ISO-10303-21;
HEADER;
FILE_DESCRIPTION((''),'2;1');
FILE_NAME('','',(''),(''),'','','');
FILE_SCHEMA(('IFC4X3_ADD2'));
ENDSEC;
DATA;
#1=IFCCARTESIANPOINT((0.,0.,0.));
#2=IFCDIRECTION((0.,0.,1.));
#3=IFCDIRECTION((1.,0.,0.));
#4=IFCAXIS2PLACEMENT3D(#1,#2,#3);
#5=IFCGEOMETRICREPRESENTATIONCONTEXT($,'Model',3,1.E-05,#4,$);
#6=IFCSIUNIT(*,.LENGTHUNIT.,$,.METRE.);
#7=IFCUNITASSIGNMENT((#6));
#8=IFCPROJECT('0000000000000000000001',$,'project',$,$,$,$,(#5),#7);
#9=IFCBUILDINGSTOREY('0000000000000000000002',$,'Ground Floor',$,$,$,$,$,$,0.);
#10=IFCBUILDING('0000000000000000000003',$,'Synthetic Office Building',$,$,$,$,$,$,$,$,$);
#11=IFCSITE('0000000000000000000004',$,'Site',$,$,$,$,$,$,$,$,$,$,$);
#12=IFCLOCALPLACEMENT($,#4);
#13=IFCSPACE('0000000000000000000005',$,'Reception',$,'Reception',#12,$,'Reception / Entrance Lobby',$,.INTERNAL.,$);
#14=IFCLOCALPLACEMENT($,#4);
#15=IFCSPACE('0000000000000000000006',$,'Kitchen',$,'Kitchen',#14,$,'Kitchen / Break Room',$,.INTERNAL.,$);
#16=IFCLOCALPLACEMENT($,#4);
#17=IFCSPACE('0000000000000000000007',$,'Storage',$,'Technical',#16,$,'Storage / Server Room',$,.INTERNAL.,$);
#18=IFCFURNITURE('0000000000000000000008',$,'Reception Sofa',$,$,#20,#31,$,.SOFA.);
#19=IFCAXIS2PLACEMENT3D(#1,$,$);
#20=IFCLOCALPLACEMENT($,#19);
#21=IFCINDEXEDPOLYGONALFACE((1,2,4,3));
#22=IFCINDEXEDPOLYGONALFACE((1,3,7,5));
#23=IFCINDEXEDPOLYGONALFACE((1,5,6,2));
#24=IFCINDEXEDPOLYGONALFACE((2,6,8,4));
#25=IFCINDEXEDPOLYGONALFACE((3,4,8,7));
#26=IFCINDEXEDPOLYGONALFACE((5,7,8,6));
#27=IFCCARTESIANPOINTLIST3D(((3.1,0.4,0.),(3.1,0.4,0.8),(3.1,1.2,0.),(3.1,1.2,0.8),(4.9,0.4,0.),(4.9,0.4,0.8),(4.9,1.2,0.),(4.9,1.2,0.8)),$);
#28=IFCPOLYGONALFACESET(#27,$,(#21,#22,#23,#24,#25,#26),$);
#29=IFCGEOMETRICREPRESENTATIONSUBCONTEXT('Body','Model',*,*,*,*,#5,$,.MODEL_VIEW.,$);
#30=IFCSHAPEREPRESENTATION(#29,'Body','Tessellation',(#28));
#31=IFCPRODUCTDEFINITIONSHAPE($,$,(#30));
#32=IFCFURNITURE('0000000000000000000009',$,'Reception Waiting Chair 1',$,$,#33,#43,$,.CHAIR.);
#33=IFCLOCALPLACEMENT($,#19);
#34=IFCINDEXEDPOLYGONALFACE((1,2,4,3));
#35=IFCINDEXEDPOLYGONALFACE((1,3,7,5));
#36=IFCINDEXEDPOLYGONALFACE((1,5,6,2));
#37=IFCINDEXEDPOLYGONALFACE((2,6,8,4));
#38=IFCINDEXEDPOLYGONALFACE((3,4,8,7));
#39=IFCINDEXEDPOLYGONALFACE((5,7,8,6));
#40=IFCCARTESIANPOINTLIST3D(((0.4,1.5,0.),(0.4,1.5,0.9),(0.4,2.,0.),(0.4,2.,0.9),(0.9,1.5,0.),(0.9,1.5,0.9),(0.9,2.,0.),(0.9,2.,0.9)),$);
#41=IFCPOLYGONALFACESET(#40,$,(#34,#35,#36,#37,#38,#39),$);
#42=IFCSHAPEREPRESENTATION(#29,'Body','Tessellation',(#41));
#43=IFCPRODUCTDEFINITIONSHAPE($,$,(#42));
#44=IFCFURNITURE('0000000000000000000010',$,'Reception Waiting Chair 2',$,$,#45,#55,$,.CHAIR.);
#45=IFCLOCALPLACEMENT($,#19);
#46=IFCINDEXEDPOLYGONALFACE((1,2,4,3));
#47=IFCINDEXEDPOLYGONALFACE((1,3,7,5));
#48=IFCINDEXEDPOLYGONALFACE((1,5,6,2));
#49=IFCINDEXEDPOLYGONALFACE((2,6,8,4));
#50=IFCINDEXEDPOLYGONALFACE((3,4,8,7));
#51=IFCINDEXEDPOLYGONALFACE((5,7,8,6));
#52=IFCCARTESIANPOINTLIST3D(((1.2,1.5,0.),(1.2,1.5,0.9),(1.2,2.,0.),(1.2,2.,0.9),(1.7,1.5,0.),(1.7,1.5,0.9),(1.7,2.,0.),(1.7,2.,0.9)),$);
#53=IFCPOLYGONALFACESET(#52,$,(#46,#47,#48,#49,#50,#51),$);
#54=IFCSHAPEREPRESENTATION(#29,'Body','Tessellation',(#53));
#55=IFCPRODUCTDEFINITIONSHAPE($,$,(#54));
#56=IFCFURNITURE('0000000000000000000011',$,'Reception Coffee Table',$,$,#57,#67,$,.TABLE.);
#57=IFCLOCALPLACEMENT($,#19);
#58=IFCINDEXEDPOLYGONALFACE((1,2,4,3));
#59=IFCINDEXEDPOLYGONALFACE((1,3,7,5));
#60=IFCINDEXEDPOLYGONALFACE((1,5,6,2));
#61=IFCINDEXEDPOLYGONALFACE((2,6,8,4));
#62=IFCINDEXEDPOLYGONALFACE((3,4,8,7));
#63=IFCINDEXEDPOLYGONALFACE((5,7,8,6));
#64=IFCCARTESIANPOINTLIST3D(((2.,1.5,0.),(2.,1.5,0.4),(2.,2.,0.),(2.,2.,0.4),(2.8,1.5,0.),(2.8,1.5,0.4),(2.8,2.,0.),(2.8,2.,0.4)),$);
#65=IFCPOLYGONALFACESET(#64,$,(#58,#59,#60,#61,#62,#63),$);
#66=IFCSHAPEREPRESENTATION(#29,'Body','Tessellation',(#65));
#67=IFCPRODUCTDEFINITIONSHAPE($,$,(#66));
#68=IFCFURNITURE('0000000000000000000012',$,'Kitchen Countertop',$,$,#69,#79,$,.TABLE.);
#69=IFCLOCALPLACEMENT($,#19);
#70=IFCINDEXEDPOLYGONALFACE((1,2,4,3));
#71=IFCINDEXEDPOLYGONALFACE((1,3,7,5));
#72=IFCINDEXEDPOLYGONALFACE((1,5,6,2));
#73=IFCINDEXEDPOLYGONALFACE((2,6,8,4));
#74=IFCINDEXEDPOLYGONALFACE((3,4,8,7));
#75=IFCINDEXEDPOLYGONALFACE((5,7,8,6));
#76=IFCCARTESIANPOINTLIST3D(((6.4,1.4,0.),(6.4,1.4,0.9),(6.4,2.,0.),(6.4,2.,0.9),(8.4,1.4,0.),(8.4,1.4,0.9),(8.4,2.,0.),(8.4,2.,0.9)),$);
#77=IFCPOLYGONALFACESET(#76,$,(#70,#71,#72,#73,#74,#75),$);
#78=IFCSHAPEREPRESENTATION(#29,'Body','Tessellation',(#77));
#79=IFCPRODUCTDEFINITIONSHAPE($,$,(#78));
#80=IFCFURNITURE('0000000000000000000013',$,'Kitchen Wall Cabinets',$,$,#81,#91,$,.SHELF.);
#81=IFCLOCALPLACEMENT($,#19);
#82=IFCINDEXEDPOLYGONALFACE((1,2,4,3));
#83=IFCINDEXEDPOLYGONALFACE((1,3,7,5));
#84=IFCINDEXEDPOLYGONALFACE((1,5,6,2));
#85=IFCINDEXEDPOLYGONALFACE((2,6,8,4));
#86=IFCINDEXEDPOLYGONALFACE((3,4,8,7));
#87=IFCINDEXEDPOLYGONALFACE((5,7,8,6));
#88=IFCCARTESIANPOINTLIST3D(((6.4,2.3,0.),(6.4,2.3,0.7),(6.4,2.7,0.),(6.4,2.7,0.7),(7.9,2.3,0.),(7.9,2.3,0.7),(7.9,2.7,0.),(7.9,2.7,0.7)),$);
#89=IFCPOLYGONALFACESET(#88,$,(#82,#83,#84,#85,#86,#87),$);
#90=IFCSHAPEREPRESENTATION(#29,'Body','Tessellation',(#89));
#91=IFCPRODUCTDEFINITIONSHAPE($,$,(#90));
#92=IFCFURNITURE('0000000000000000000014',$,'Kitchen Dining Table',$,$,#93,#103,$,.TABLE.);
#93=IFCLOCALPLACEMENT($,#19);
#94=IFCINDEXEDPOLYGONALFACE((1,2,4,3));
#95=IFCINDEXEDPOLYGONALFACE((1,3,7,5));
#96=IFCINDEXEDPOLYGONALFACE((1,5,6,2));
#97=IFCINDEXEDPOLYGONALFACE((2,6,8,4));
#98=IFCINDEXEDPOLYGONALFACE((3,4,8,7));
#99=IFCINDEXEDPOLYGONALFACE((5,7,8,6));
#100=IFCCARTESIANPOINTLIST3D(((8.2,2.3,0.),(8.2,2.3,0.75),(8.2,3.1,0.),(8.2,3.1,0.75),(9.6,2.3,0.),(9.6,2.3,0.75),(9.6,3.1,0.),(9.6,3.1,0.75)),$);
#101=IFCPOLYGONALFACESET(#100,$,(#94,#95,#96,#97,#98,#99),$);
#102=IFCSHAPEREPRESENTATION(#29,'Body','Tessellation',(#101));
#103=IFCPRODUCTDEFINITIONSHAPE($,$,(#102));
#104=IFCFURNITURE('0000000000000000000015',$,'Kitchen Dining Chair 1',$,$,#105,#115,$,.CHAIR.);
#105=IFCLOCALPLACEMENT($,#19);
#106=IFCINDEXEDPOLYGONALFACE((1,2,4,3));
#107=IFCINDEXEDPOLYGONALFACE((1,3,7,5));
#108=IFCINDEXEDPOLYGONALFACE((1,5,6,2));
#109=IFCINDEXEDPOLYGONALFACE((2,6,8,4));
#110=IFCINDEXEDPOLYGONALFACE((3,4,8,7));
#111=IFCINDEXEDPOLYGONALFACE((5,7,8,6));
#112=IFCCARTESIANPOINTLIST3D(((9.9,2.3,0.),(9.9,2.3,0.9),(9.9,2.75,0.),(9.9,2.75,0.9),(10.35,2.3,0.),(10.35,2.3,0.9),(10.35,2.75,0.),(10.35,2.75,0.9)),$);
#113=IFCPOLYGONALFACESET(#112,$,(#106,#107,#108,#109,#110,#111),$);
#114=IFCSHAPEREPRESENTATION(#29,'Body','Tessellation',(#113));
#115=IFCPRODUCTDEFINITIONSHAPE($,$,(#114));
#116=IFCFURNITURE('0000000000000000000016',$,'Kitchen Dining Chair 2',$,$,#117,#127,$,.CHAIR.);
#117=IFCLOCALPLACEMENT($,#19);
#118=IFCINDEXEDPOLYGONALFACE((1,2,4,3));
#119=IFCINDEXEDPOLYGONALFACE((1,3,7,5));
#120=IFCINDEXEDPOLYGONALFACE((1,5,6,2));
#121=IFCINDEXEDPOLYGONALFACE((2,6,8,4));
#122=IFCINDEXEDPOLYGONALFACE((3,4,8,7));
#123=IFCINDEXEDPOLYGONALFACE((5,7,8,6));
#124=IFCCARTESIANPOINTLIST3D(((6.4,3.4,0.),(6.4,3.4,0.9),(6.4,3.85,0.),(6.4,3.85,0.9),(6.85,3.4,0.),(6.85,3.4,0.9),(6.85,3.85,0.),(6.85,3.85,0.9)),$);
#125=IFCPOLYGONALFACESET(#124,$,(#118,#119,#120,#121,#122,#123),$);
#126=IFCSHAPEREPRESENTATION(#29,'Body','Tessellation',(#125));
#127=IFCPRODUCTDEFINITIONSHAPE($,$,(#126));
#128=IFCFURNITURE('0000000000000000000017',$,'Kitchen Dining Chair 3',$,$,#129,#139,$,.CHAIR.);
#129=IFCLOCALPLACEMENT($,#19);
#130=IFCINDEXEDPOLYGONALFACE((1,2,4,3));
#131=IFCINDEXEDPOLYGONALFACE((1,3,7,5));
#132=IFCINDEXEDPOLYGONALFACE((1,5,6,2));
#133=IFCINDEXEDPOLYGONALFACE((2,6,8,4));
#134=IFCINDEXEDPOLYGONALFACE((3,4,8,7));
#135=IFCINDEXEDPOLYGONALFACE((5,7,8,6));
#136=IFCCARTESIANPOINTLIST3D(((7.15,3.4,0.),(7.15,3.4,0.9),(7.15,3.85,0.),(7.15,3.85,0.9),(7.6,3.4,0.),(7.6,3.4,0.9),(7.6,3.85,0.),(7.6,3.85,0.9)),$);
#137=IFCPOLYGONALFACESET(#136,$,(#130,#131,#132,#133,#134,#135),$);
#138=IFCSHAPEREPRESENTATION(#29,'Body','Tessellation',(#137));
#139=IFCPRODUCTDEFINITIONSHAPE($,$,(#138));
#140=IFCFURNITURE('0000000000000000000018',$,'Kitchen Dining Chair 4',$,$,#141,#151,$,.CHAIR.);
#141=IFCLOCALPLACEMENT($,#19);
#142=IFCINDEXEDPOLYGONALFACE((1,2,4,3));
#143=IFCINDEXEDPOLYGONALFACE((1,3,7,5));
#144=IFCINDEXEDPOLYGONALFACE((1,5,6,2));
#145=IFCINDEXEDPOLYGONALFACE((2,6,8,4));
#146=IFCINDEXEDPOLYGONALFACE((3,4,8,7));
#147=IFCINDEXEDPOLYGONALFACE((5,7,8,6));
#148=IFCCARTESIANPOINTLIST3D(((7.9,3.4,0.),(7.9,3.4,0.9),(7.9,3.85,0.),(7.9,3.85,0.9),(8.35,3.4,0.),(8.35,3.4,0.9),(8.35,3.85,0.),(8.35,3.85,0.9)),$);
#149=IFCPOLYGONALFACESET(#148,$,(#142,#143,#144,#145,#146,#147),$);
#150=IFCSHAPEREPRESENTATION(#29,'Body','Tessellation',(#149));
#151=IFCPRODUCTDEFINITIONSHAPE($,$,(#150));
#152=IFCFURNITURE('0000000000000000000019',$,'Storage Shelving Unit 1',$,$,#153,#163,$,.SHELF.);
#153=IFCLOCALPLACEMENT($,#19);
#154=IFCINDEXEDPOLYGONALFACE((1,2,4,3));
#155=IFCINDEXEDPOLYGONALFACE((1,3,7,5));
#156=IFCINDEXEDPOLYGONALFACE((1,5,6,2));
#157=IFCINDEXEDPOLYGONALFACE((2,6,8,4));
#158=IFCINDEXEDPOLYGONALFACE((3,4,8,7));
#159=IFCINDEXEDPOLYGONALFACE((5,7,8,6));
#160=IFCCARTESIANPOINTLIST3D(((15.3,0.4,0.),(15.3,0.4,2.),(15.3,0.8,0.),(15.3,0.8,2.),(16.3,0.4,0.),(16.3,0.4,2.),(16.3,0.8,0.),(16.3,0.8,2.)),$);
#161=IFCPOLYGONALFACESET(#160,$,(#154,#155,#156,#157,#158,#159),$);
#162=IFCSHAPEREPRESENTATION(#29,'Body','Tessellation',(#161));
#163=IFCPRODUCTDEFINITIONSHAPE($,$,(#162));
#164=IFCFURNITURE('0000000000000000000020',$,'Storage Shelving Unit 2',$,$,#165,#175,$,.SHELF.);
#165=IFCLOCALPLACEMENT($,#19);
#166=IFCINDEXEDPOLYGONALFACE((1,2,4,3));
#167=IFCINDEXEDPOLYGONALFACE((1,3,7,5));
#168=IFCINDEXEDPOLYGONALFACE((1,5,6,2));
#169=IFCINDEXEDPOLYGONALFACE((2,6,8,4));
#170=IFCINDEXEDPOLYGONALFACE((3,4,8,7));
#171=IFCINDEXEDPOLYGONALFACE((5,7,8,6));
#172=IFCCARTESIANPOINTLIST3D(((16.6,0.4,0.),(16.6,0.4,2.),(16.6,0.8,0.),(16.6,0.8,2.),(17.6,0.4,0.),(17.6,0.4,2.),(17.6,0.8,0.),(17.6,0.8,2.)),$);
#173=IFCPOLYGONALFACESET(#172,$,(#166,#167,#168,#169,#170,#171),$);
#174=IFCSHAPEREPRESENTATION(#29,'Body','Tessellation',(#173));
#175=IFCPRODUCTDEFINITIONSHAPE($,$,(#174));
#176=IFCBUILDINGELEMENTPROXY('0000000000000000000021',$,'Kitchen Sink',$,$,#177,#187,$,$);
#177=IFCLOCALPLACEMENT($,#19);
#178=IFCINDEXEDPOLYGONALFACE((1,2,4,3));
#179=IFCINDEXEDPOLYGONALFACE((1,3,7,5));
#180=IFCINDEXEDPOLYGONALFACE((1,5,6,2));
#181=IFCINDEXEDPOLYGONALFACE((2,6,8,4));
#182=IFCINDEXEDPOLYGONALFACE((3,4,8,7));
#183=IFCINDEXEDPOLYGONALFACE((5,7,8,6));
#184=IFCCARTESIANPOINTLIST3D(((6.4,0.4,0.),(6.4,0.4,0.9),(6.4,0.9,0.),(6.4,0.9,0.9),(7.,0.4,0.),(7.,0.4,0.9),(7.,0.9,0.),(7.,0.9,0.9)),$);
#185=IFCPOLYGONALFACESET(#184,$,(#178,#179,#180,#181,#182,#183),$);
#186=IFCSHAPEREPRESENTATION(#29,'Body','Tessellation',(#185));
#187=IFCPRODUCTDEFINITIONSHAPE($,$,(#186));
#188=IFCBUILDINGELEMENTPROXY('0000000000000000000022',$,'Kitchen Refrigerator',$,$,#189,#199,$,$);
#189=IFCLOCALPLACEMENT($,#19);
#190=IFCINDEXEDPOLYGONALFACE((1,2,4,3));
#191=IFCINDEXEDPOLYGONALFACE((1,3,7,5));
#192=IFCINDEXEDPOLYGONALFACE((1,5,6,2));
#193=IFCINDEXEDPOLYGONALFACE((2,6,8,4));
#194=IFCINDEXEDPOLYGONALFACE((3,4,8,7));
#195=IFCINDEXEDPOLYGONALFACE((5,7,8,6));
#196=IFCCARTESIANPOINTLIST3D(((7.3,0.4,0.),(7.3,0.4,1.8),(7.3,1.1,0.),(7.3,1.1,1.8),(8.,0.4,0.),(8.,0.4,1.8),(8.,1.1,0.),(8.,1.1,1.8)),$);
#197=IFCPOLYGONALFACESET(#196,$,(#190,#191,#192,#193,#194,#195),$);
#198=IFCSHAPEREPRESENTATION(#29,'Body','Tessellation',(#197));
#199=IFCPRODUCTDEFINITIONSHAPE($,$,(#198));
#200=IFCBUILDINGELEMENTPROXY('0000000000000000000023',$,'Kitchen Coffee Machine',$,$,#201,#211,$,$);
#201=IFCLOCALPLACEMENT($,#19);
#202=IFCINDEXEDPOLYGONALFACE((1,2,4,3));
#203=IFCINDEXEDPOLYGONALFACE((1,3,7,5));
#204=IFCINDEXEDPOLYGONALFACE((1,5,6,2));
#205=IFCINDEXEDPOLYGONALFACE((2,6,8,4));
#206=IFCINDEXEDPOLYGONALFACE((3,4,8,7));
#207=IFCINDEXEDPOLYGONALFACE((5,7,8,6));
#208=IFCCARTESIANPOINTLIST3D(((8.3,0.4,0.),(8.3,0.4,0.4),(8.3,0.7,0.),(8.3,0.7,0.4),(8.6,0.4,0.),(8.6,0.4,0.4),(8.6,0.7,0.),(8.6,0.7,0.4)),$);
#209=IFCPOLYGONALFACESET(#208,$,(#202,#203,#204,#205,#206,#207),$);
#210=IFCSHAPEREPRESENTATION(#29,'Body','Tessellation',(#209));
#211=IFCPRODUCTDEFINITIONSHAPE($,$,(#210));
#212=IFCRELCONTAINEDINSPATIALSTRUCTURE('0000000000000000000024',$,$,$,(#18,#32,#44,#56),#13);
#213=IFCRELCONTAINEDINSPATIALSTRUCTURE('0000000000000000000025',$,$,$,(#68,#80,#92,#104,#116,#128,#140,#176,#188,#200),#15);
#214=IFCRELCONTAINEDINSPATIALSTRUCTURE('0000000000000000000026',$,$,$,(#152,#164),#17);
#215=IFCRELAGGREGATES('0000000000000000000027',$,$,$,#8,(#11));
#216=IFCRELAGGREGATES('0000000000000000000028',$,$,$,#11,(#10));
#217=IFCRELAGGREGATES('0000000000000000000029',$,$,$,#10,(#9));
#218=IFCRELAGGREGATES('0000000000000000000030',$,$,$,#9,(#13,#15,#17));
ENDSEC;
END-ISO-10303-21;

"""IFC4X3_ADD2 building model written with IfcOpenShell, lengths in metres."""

from ifc_helpers import new_model, si_unit, origin_with_axes, place, context, subcontext, project, spatial, polyline, outline, extrude, element, save


model = new_model("IFC4X3_ADD2")

# Units and contexts
model_context = context("Model", 3, precision=1e-05, world=origin_with_axes())
body_context = subcontext(model_context, "Body", "Model", "MODEL_VIEW")
ifc_project = project(units=[si_unit("LENGTHUNIT", "METRE")], contexts=[model_context])

# Site, building, storey, space
site = spatial("IfcSite", under=ifc_project, Name="Site")
building = spatial("IfcBuilding", under=site, Name="Synthetic Office Building")
storey = spatial("IfcBuildingStorey", under=building, Name="Ground Floor", Elevation=0.0)
space_1_placement = place(None, origin_with_axes())
space_1 = spatial("IfcSpace", under=storey, at=space_1_placement, Name="Reception", ObjectType="Reception", LongName="Reception / Entrance Lobby", PredefinedType="INTERNAL")

# Furniture
furniture_1_placement = place(space_1_placement, origin_with_axes())
element("IfcFurniture", 1, at=furniture_1_placement, inside=space_1, Name="Reception Sofa", PredefinedType="SOFA", context=body_context, shape_type="SweptSolid", body=[
    extrude(outline(polyline([(3.1, 0.4), (4.9, 0.4), (4.9, 1.2), (3.1, 1.2), (3.1, 0.4)])), origin_with_axes(), (0.0, 0.0, 1.0), 0.8),
])
furniture_2_placement = place(space_1_placement, origin_with_axes())
element("IfcFurniture", 2, at=furniture_2_placement, inside=space_1, Name="Reception Waiting Chair 1", PredefinedType="CHAIR", context=body_context, shape_type="SweptSolid", body=[
    extrude(outline(polyline([(0.4, 1.5), (0.9, 1.5), (0.9, 2.0), (0.4, 2.0), (0.4, 1.5)])), origin_with_axes(), (0.0, 0.0, 1.0), 0.9),
])
furniture_3_placement = place(space_1_placement, origin_with_axes())
element("IfcFurniture", 3, at=furniture_3_placement, inside=space_1, Name="Reception Waiting Chair 2", PredefinedType="CHAIR", context=body_context, shape_type="SweptSolid", body=[
    extrude(outline(polyline([(1.2, 1.5), (1.7, 1.5), (1.7, 2.0), (1.2, 2.0), (1.2, 1.5)])), origin_with_axes(), (0.0, 0.0, 1.0), 0.9),
])
furniture_4_placement = place(space_1_placement, origin_with_axes())
element("IfcFurniture", 4, at=furniture_4_placement, inside=space_1, Name="Reception Coffee Table", PredefinedType="TABLE", context=body_context, shape_type="SweptSolid", body=[
    extrude(outline(polyline([(2.0, 1.5), (2.8, 1.5), (2.8, 2.0), (2.0, 2.0), (2.0, 1.5)])), origin_with_axes(), (0.0, 0.0, 1.0), 0.4),
])

# Shared definitions
space_2_placement = place(None, origin_with_axes())
space_2 = spatial("IfcSpace", under=storey, at=space_2_placement, Name="Kitchen", ObjectType="Kitchen", LongName="Kitchen / Break Room", PredefinedType="INTERNAL")

# Furniture
furniture_5_placement = place(space_2_placement, origin_with_axes())
element("IfcFurniture", 5, at=furniture_5_placement, inside=space_2, Name="Kitchen Countertop", PredefinedType="TABLE", context=body_context, shape_type="SweptSolid", body=[
    extrude(outline(polyline([(6.4, 1.4), (8.4, 1.4), (8.4, 2.0), (6.4, 2.0), (6.4, 1.4)])), origin_with_axes(), (0.0, 0.0, 1.0), 0.9),
])
furniture_6_placement = place(space_2_placement, origin_with_axes())
element("IfcFurniture", 6, at=furniture_6_placement, inside=space_2, Name="Kitchen Wall Cabinets", PredefinedType="SHELF", context=body_context, shape_type="SweptSolid", body=[
    extrude(outline(polyline([(6.4, 2.3), (7.9, 2.3), (7.9, 2.7), (6.4, 2.7), (6.4, 2.3)])), origin_with_axes(), (0.0, 0.0, 1.0), 0.7),
])
furniture_7_placement = place(space_2_placement, origin_with_axes())
element("IfcFurniture", 7, at=furniture_7_placement, inside=space_2, Name="Kitchen Dining Table", PredefinedType="TABLE", context=body_context, shape_type="SweptSolid", body=[
    extrude(outline(polyline([(8.2, 2.3), (9.6, 2.3), (9.6, 3.1), (8.2, 3.1), (8.2, 2.3)])), origin_with_axes(), (0.0, 0.0, 1.0), 0.75),
])
furniture_8_placement = place(space_2_placement, origin_with_axes())
element("IfcFurniture", 8, at=furniture_8_placement, inside=space_2, Name="Kitchen Dining Chair 1", PredefinedType="CHAIR", context=body_context, shape_type="SweptSolid", body=[
    extrude(outline(polyline([(9.9, 2.3), (10.35, 2.3), (10.35, 2.75), (9.9, 2.75), (9.9, 2.3)])), origin_with_axes(), (0.0, 0.0, 1.0), 0.9),
])
furniture_9_placement = place(space_2_placement, origin_with_axes())
element("IfcFurniture", 9, at=furniture_9_placement, inside=space_2, Name="Kitchen Dining Chair 2", PredefinedType="CHAIR", context=body_context, shape_type="SweptSolid", body=[
    extrude(outline(polyline([(6.4, 3.4), (6.85, 3.4), (6.85, 3.85), (6.4, 3.85), (6.4, 3.4)])), origin_with_axes(), (0.0, 0.0, 1.0), 0.9),
])
furniture_10_placement = place(space_2_placement, origin_with_axes())
element("IfcFurniture", 10, at=furniture_10_placement, inside=space_2, Name="Kitchen Dining Chair 3", PredefinedType="CHAIR", context=body_context, shape_type="SweptSolid", body=[
    extrude(outline(polyline([(7.15, 3.4), (7.6, 3.4), (7.6, 3.85), (7.15, 3.85), (7.15, 3.4)])), origin_with_axes(), (0.0, 0.0, 1.0), 0.9),
])
furniture_11_placement = place(space_2_placement, origin_with_axes())
element("IfcFurniture", 11, at=furniture_11_placement, inside=space_2, Name="Kitchen Dining Chair 4", PredefinedType="CHAIR", context=body_context, shape_type="SweptSolid", body=[
    extrude(outline(polyline([(7.9, 3.4), (8.35, 3.4), (8.35, 3.85), (7.9, 3.85), (7.9, 3.4)])), origin_with_axes(), (0.0, 0.0, 1.0), 0.9),
])

# Shared definitions
space_3_placement = place(None, origin_with_axes())
space_3 = spatial("IfcSpace", under=storey, at=space_3_placement, Name="Storage", ObjectType="Technical", LongName="Storage / Server Room", PredefinedType="INTERNAL")

# Furniture
furniture_12_placement = place(space_3_placement, origin_with_axes())
element("IfcFurniture", 12, at=furniture_12_placement, inside=space_3, Name="Storage Shelving Unit 1", PredefinedType="SHELF", context=body_context, shape_type="SweptSolid", body=[
    extrude(outline(polyline([(15.3, 0.4), (16.3, 0.4), (16.3, 0.8), (15.3, 0.8), (15.3, 0.4)])), origin_with_axes(), (0.0, 0.0, 1.0), 2.0),
])
furniture_13_placement = place(space_3_placement, origin_with_axes())
element("IfcFurniture", 13, at=furniture_13_placement, inside=space_3, Name="Storage Shelving Unit 2", PredefinedType="SHELF", context=body_context, shape_type="SweptSolid", body=[
    extrude(outline(polyline([(16.6, 0.4), (17.6, 0.4), (17.6, 0.8), (16.6, 0.8), (16.6, 0.4)])), origin_with_axes(), (0.0, 0.0, 1.0), 2.0),
])

# Building element proxies
proxy_1_placement = place(space_2_placement, origin_with_axes())
element("IfcBuildingElementProxy", 14, at=proxy_1_placement, inside=space_2, Name="Kitchen Sink", context=body_context, shape_type="SweptSolid", body=[
    extrude(outline(polyline([(6.4, 0.4), (7.0, 0.4), (7.0, 0.9), (6.4, 0.9), (6.4, 0.4)])), origin_with_axes(), (0.0, 0.0, 1.0), 0.9),
])
proxy_2_placement = place(space_2_placement, origin_with_axes())
element("IfcBuildingElementProxy", 15, at=proxy_2_placement, inside=space_2, Name="Kitchen Refrigerator", context=body_context, shape_type="SweptSolid", body=[
    extrude(outline(polyline([(7.3, 0.4), (8.0, 0.4), (8.0, 1.1), (7.3, 1.1), (7.3, 0.4)])), origin_with_axes(), (0.0, 0.0, 1.0), 1.8),
])
proxy_3_placement = place(space_2_placement, origin_with_axes())
element("IfcBuildingElementProxy", 16, at=proxy_3_placement, inside=space_2, Name="Kitchen Coffee Machine", context=body_context, shape_type="SweptSolid", body=[
    extrude(outline(polyline([(8.3, 0.4), (8.6, 0.4), (8.6, 0.7), (8.3, 0.7), (8.3, 0.4)])), origin_with_axes(), (0.0, 0.0, 1.0), 0.4),
])

save(model, "model.ifc")
